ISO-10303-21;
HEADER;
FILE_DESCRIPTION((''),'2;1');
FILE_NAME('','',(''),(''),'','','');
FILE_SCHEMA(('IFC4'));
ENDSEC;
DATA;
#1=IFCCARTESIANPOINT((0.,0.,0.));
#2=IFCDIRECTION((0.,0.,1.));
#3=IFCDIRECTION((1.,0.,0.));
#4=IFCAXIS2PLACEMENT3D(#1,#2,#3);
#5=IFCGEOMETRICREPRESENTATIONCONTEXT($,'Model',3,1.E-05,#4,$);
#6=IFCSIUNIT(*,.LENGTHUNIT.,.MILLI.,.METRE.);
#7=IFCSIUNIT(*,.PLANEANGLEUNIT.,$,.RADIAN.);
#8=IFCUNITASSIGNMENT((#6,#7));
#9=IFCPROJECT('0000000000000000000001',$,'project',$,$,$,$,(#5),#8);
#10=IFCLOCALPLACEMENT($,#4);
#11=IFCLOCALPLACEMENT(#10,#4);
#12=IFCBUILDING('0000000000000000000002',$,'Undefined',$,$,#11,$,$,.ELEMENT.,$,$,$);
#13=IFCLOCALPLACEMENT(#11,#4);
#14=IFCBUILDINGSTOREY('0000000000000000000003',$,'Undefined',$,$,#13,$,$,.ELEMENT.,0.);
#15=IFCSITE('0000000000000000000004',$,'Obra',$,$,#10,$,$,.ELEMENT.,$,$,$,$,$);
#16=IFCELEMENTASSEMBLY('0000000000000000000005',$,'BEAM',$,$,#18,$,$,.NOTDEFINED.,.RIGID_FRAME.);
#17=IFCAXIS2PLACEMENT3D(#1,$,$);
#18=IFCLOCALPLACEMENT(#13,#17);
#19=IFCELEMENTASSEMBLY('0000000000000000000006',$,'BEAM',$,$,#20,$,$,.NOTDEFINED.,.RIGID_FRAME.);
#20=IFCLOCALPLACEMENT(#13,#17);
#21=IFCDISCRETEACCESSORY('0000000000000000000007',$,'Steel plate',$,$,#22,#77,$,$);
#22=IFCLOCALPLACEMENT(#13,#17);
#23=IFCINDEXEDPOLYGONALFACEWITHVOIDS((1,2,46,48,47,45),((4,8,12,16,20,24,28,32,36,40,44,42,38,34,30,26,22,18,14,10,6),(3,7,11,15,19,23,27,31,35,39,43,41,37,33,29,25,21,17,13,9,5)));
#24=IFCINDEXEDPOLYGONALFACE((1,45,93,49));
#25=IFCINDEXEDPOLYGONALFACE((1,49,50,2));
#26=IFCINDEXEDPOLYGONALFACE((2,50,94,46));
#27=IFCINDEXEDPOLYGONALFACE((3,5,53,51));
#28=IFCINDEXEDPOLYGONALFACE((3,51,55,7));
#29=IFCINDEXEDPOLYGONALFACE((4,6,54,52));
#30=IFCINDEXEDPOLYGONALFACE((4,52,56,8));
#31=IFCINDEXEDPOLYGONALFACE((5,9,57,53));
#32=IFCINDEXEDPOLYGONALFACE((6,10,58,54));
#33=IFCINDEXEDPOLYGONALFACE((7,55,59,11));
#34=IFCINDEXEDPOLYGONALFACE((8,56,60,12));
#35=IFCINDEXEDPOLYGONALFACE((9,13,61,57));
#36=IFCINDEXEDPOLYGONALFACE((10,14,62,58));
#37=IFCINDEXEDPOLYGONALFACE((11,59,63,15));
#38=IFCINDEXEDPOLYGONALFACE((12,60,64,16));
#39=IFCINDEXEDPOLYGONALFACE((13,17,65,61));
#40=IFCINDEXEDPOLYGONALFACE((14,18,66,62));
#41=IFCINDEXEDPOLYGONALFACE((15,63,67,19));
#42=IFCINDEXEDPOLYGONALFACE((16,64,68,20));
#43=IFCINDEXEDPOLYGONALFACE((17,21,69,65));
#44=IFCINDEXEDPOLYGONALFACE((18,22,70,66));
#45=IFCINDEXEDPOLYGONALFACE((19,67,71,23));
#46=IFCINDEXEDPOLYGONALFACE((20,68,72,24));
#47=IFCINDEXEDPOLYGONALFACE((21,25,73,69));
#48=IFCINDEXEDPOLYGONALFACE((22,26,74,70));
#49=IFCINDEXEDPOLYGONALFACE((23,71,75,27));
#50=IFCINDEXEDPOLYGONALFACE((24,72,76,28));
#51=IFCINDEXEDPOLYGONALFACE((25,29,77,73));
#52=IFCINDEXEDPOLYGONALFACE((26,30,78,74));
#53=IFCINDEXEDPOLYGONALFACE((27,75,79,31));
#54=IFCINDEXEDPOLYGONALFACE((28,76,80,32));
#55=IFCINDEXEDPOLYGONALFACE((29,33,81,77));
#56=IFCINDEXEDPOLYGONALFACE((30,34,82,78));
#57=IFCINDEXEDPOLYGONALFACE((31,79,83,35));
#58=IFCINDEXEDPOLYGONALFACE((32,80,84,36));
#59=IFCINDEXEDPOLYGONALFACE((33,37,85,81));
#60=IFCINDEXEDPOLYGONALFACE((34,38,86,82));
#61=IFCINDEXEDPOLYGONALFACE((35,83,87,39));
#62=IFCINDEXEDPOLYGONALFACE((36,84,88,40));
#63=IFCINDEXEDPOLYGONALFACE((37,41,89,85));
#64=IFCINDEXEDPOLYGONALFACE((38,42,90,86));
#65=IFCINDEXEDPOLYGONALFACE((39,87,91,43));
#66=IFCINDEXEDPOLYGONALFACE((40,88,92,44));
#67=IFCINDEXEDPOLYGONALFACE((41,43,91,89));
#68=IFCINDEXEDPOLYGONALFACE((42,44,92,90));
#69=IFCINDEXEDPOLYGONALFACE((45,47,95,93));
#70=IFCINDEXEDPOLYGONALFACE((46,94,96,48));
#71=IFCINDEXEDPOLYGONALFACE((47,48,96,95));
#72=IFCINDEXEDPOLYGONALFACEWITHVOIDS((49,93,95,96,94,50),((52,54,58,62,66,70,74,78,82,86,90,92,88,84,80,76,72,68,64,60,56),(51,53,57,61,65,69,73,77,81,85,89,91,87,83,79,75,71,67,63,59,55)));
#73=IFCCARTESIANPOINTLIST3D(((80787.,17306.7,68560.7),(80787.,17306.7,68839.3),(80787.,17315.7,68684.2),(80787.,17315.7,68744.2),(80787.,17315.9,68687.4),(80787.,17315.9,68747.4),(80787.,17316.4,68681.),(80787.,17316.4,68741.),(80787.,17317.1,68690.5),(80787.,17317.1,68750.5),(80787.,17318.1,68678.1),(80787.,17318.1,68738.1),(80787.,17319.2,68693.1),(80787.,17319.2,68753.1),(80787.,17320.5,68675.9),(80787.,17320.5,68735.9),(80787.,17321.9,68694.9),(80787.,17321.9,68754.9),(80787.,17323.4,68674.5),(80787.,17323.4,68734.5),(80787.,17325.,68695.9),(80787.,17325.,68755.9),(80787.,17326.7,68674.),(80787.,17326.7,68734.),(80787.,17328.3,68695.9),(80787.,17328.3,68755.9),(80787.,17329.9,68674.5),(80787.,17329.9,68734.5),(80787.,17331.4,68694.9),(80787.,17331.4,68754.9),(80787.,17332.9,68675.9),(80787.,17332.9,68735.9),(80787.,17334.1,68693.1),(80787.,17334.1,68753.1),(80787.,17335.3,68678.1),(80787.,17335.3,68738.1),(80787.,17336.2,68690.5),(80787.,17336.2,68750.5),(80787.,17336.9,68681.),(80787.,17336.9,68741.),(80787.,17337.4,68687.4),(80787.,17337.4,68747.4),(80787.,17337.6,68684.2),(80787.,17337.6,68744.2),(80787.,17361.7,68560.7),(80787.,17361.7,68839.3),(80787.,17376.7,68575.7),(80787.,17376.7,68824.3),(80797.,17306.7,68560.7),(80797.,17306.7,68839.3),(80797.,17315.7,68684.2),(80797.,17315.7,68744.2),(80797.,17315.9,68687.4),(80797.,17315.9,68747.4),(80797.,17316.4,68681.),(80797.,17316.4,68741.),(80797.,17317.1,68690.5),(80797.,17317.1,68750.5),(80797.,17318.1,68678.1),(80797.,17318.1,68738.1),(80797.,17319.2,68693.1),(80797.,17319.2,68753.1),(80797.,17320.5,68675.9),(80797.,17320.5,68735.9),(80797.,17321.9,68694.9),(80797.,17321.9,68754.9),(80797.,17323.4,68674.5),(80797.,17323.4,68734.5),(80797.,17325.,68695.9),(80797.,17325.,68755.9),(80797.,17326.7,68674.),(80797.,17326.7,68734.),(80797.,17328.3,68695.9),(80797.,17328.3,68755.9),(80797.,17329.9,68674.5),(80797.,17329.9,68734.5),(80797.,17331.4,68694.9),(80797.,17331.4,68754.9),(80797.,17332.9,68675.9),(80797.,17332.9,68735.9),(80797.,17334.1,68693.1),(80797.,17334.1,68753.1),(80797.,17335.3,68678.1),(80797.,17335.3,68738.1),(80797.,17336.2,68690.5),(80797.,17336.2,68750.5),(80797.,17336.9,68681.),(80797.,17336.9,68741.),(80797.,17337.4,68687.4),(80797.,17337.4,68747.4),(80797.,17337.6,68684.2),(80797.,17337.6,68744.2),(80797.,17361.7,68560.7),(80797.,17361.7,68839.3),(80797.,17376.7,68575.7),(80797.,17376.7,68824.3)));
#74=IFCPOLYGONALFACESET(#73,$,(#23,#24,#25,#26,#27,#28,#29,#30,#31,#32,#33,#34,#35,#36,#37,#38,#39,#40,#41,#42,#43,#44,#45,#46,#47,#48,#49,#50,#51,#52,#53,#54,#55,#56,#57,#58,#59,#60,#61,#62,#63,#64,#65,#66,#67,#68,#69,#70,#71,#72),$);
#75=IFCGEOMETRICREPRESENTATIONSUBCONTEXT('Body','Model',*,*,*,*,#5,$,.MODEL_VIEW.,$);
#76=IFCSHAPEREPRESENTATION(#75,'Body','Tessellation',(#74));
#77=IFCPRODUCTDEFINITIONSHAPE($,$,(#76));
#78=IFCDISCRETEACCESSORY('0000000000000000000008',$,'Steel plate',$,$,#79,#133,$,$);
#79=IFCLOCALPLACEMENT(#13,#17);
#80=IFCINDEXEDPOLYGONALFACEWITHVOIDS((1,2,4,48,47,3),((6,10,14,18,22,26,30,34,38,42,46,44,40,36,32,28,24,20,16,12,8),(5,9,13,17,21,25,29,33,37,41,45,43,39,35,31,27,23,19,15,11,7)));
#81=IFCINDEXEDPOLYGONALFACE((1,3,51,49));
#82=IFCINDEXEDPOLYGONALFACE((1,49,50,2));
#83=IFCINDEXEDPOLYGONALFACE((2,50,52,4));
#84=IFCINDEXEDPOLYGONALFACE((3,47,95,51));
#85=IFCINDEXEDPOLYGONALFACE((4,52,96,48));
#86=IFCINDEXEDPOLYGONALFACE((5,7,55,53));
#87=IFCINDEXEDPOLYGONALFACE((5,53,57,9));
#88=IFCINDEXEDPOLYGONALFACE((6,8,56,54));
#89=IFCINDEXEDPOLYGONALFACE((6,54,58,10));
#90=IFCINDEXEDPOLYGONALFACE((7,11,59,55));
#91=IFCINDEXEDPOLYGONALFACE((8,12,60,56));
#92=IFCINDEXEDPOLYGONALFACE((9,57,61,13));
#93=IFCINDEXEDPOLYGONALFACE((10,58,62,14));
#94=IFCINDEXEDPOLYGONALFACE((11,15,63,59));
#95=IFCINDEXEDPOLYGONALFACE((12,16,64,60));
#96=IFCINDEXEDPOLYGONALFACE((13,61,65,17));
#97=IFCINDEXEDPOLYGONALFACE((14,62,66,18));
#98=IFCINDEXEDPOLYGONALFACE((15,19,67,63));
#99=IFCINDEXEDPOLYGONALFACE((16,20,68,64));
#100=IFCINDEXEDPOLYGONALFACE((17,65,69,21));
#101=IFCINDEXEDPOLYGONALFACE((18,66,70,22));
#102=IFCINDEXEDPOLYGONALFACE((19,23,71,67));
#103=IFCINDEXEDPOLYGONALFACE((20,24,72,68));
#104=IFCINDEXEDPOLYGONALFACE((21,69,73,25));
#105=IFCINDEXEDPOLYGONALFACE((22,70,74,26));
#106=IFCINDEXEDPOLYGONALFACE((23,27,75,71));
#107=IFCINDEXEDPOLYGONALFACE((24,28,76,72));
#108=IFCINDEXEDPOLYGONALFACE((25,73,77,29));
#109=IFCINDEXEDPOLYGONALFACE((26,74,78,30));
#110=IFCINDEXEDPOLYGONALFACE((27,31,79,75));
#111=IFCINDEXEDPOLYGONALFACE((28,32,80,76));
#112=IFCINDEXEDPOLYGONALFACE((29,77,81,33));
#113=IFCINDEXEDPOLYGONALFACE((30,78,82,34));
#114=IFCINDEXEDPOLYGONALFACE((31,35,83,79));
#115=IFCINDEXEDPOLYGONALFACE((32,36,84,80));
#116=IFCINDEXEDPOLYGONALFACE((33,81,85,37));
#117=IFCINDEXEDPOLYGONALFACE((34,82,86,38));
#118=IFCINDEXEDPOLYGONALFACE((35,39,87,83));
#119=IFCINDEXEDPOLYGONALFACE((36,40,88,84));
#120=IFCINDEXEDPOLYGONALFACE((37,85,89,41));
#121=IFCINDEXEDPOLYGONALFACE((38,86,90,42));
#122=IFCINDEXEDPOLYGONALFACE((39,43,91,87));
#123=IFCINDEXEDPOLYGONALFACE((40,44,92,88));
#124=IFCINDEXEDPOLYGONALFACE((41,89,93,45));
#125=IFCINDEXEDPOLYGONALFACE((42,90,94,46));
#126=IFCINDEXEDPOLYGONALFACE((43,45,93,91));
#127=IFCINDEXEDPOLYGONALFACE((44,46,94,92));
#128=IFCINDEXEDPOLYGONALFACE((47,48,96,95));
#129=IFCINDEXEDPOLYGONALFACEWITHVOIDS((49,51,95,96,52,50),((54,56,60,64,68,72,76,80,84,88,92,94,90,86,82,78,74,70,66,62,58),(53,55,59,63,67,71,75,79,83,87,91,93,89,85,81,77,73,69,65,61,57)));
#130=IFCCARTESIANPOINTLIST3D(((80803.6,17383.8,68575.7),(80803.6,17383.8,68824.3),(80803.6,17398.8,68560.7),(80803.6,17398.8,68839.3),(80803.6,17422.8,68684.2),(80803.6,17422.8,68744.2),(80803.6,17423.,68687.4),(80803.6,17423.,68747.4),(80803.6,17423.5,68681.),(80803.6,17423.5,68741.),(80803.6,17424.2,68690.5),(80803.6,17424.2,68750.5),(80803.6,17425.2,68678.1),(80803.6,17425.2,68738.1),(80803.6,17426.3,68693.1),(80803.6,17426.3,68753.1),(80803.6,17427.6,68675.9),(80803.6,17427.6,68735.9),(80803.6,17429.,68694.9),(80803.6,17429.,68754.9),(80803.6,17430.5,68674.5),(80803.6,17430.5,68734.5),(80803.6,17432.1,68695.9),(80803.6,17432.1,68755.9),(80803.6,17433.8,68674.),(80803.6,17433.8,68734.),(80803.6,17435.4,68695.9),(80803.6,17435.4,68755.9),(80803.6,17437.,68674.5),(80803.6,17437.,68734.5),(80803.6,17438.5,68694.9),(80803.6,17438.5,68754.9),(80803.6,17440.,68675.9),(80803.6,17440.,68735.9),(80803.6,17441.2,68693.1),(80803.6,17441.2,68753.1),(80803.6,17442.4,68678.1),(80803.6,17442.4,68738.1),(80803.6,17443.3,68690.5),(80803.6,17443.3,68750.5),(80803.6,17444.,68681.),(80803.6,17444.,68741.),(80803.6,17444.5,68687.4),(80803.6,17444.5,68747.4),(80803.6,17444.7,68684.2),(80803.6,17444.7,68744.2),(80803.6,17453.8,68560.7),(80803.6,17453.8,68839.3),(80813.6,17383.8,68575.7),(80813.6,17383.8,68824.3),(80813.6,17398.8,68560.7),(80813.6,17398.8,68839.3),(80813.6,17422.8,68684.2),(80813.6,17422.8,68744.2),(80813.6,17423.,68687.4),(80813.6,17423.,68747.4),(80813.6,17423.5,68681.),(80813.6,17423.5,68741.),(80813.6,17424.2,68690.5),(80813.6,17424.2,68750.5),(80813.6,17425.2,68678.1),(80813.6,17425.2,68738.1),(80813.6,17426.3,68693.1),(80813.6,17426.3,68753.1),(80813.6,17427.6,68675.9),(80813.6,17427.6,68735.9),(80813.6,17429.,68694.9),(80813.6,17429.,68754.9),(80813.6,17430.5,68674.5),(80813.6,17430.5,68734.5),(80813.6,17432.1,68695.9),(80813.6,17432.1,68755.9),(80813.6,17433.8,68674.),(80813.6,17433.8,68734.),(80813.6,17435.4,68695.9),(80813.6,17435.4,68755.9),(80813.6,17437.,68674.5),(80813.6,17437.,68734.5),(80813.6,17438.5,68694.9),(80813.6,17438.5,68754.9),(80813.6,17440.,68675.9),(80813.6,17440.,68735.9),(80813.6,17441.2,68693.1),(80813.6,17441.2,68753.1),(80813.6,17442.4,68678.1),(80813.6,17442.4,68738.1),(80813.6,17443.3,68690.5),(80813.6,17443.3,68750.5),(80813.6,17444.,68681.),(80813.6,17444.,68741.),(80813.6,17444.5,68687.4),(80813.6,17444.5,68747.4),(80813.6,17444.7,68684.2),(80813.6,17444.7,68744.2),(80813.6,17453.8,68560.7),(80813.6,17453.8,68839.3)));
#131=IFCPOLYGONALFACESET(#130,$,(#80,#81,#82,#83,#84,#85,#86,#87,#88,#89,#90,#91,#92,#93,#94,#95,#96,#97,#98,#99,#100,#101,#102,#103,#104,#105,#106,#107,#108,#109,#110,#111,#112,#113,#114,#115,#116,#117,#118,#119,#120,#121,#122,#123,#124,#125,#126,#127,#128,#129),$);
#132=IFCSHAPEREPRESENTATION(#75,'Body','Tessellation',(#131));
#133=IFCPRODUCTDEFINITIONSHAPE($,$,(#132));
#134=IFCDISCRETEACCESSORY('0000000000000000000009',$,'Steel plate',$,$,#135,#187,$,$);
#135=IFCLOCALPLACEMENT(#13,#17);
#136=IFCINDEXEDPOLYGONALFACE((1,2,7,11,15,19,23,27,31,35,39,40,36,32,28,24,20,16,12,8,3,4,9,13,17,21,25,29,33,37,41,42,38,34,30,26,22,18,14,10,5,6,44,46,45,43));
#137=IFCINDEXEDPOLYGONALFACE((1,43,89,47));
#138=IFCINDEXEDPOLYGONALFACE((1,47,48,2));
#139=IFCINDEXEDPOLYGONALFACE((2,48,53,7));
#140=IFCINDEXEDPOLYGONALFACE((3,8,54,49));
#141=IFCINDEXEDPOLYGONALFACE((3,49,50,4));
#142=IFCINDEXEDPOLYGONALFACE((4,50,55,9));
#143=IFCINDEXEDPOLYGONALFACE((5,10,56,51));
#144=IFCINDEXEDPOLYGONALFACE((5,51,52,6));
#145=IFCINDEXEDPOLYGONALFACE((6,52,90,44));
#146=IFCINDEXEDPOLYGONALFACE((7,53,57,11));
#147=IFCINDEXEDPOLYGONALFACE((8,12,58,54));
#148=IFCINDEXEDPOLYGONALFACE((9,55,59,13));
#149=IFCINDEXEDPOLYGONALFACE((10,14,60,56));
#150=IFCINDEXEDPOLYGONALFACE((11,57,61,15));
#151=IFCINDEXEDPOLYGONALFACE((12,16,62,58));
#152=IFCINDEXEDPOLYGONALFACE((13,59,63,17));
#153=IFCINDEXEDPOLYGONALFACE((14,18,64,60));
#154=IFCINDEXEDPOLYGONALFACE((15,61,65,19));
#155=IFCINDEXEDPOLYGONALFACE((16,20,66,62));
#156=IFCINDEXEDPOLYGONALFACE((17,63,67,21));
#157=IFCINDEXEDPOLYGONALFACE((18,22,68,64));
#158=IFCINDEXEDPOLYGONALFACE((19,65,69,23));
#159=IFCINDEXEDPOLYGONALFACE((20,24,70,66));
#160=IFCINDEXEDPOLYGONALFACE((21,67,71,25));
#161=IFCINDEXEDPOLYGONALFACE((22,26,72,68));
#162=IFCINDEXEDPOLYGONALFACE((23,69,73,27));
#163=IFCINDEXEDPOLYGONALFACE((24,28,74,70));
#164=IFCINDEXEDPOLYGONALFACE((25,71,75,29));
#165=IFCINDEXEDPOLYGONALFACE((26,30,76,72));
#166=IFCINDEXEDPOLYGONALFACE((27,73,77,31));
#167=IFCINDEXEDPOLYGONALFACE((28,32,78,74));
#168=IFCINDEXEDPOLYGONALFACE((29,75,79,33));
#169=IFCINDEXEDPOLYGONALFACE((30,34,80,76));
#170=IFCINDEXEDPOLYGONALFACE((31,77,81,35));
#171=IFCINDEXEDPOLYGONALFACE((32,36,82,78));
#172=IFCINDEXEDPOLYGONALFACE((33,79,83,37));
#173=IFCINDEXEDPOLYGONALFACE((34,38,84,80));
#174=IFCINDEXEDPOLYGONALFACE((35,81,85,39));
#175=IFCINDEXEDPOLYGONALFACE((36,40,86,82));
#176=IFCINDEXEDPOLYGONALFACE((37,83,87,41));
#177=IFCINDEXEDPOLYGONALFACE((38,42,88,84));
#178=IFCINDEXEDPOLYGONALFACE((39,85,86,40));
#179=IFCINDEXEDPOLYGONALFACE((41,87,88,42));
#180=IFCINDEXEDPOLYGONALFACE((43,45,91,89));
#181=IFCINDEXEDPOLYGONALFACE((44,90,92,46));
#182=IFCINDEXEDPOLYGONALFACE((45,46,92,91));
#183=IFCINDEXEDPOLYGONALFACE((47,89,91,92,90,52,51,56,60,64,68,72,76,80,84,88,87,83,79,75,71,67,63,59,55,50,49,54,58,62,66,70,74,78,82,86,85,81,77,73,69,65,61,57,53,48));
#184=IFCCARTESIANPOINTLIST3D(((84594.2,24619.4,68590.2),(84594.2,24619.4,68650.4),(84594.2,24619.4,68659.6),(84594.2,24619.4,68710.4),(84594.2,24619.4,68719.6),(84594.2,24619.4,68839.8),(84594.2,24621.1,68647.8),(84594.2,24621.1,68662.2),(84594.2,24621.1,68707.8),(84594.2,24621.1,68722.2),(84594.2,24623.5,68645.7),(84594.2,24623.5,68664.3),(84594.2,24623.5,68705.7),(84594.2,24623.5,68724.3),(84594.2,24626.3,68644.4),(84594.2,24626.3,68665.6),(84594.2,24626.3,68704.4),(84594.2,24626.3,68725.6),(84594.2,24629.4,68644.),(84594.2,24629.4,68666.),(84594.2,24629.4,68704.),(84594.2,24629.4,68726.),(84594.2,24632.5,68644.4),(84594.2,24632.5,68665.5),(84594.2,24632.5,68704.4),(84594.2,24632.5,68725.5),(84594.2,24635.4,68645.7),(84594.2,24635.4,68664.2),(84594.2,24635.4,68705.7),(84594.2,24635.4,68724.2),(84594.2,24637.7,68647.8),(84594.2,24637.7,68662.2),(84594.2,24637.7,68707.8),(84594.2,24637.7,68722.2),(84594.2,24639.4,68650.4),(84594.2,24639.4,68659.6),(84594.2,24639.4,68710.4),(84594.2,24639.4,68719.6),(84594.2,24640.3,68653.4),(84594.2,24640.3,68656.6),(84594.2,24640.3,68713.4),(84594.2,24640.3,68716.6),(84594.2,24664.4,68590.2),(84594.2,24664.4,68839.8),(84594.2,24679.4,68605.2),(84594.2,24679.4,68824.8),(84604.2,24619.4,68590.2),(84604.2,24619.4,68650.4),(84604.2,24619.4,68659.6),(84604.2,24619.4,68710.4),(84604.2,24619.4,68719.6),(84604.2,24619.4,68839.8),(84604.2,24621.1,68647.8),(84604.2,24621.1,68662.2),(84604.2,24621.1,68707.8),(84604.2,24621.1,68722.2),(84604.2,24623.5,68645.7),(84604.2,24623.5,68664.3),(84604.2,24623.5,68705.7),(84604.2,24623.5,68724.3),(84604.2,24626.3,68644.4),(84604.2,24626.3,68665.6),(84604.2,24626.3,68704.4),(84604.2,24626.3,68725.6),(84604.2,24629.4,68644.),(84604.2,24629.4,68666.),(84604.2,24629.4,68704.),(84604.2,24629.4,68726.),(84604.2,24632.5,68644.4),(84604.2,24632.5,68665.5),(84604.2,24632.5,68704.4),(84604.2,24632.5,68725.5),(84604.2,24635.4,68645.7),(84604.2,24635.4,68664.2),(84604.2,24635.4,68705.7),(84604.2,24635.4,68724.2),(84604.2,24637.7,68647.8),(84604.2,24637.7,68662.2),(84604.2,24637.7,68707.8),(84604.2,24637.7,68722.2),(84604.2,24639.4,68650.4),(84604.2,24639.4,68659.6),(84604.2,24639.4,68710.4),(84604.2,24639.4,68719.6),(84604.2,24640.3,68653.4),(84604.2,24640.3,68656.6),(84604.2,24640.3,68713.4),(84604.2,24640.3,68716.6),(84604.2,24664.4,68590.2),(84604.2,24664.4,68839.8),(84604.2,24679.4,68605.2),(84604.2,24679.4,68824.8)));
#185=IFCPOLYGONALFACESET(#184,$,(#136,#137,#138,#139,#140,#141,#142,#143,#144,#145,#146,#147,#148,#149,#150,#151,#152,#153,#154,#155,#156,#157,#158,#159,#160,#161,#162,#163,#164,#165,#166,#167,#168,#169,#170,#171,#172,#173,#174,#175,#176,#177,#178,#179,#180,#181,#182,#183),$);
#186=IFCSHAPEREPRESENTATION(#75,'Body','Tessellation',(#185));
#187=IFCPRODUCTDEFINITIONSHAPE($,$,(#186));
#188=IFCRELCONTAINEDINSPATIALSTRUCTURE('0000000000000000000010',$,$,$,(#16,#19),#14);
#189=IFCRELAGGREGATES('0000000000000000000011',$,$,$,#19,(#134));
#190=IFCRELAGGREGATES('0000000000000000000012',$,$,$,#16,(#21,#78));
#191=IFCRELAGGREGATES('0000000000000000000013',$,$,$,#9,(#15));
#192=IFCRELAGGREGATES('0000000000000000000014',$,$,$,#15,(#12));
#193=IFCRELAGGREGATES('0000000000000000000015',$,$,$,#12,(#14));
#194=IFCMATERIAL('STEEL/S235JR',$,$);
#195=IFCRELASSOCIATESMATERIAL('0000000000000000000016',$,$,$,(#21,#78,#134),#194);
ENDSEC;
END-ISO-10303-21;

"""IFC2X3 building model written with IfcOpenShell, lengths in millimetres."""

from ifc_helpers import new_model, si_unit, frame, origin_with_axes, origin_2d_with_axis, place, context, subcontext, project, spatial, polyline, circle, outline, extrude, source, transform, mapped, material, element, aggregate, save


model = new_model("IFC2X3")

# Units and contexts
model_context = context("Model", 3, precision=1e-05, world=origin_with_axes())
body_context = subcontext(model_context, "Body", "Model", "MODEL_VIEW")
ifc_project = project(units=[si_unit("LENGTHUNIT", "METRE", prefix="MILLI"), si_unit("PLANEANGLEUNIT", "RADIAN")], contexts=[model_context])

# Site, building, storey
site_placement = place(None, origin_with_axes())
site = spatial("IfcSite", under=ifc_project, at=site_placement, Name="Obra", CompositionType="ELEMENT")
building_placement = place(site_placement, origin_with_axes())
building = spatial("IfcBuilding", under=site, at=building_placement, Name="Undefined", CompositionType="ELEMENT")
storey_placement = place(building_placement, origin_with_axes())
storey = spatial("IfcBuildingStorey", under=building, at=storey_placement, Name="Undefined", CompositionType="ELEMENT", Elevation=0.0)

# Shared definitions
ifc_material = material(Name="STEEL/S235JR")

# Element assembly
assembly_1_placement = place(storey_placement, origin_with_axes())
assembly_1 = element("IfcElementAssembly", 1, at=assembly_1_placement, inside=storey, Name="BEAM", AssemblyPlace="NOTDEFINED", PredefinedType="RIGID_FRAME")

# Element assembly
assembly_2_placement = place(storey_placement, origin_with_axes())
assembly_2 = element("IfcElementAssembly", 2, at=assembly_2_placement, inside=storey, Name="BEAM", AssemblyPlace="NOTDEFINED", PredefinedType="RIGID_FRAME")
shared_shape_1 = source(origin_with_axes(), body_context, "Body", "SweptSolid", [
    extrude(circle(Radius=11.0, at=origin_2d_with_axis()), frame((0.0, -13.4, 0.0), z_axis=(0.0, 1.0, 0.0), x_axis=(1.0, 0.0, 0.0)), (0.0, 0.0, 1.0), 10.2),
])

# Discrete accessories, openings
discrete_accessory_1_placement = place(assembly_1_placement, frame((80792.0, 17306.7, 68560.7), z_axis=(1.0, 0.0, 0.0), x_axis=(0.0, 1.0, 0.0)))
discrete_accessory_1 = element("IfcDiscreteAccessory", 3, at=discrete_accessory_1_placement, material=ifc_material, Name="Steel plate", context=body_context, shape_type="SweptSolid", body=[
    extrude(outline(polyline([(0.0, 0.0), (55.0, 0.0), (70.0, 15.0), (70.0, 263.6), (55.0, 278.6), (0.0, 278.6), (0.0, 0.0)])), frame((0.0, 0.0, -5.0), z_axis=(0.0, 0.0, 1.0), x_axis=(1.0, 0.0, 0.0)), (0.0, 0.0, 1.0), 10.0),
])
opening_1_placement = place(assembly_1_placement, frame((80800.3, 17366.7, 68850.0), z_axis=(0.0, -1.0, 0.0), x_axis=(0.0, 0.0, -1.0)))
element("IfcOpeningElement", 4, at=opening_1_placement, cuts=discrete_accessory_1, ObjectType="Opening", context=body_context, shape_type="MappedRepresentation", body=[
    mapped(shared_shape_1, transform((105.0, 0.0, 40.0))),
    mapped(shared_shape_1, transform((165.0, 0.0, 40.0))),
])
discrete_accessory_2_placement = place(assembly_1_placement, frame((80808.6, 17453.8, 68560.7), z_axis=(-1.0, 0.0, 0.0), x_axis=(0.0, -1.0, 0.0)))
discrete_accessory_2 = element("IfcDiscreteAccessory", 5, at=discrete_accessory_2_placement, material=ifc_material, Name="Steel plate", context=body_context, shape_type="SweptSolid", body=[
    extrude(outline(polyline([(0.0, 0.0), (55.0, 0.0), (70.0, 15.0), (70.0, 263.6), (55.0, 278.6), (0.0, 278.6), (0.0, 0.0)])), frame((0.0, 0.0, -5.0), z_axis=(0.0, 0.0, 1.0), x_axis=(1.0, 0.0, 0.0)), (0.0, 0.0, 1.0), 10.0),
])
opening_2_placement = place(assembly_1_placement, frame((80800.3, 17393.8, 68850.0), z_axis=(0.0, 1.0, 0.0), x_axis=(0.0, 0.0, -1.0)))
element("IfcOpeningElement", 6, at=opening_2_placement, cuts=discrete_accessory_2, ObjectType="Opening", context=body_context, shape_type="MappedRepresentation", body=[
    mapped(shared_shape_1, transform((105.0, 0.0, 40.0))),
    mapped(shared_shape_1, transform((165.0, 0.0, 40.0))),
])
discrete_accessory_3_placement = place(assembly_2_placement, frame((84599.2, 24619.4, 68590.2), z_axis=(1.0, 0.000001, 0.0), x_axis=(-0.000002, 1.0, 0.0)))
discrete_accessory_3 = element("IfcDiscreteAccessory", 7, at=discrete_accessory_3_placement, material=ifc_material, Name="Steel plate", context=body_context, shape_type="SweptSolid", body=[
    extrude(outline(polyline([(0.0, 0.0), (45.0, 0.0), (60.0, 15.0), (60.0, 234.6), (45.0, 249.6), (0.0, 249.6), (0.0, 0.0)])), frame((0.0, 0.0, -5.0), z_axis=(0.0, 0.0, 1.0), x_axis=(1.0, 0.0, 0.0)), (0.0, 0.0, 1.0), 10.0),
])
shared_shape_2 = source(origin_with_axes(), body_context, "Body", "SweptSolid", [
    extrude(circle(Radius=11.0, at=origin_2d_with_axis()), frame((0.0, -13.9, 0.0), z_axis=(0.0, 1.0, 0.0), x_axis=(1.0, 0.0, 0.0)), (0.0, 0.0, 1.0), 10.2),
])
opening_3_placement = place(assembly_2_placement, frame((84607.9, 24669.4, 68850.0), z_axis=(0.000002, -1.0, 0.0), x_axis=(0.0, 0.0, -1.0)))
element("IfcOpeningElement", 8, at=opening_3_placement, cuts=discrete_accessory_3, ObjectType="Opening", context=body_context, shape_type="MappedRepresentation", body=[
    mapped(shared_shape_2, transform((135.0, 0.0, 40.0))),
    mapped(shared_shape_2, transform((195.0, 0.0, 40.0))),
])
aggregate(assembly_2, [discrete_accessory_3])
aggregate(assembly_1, [discrete_accessory_1, discrete_accessory_2])

save(model, "model.ifc")
